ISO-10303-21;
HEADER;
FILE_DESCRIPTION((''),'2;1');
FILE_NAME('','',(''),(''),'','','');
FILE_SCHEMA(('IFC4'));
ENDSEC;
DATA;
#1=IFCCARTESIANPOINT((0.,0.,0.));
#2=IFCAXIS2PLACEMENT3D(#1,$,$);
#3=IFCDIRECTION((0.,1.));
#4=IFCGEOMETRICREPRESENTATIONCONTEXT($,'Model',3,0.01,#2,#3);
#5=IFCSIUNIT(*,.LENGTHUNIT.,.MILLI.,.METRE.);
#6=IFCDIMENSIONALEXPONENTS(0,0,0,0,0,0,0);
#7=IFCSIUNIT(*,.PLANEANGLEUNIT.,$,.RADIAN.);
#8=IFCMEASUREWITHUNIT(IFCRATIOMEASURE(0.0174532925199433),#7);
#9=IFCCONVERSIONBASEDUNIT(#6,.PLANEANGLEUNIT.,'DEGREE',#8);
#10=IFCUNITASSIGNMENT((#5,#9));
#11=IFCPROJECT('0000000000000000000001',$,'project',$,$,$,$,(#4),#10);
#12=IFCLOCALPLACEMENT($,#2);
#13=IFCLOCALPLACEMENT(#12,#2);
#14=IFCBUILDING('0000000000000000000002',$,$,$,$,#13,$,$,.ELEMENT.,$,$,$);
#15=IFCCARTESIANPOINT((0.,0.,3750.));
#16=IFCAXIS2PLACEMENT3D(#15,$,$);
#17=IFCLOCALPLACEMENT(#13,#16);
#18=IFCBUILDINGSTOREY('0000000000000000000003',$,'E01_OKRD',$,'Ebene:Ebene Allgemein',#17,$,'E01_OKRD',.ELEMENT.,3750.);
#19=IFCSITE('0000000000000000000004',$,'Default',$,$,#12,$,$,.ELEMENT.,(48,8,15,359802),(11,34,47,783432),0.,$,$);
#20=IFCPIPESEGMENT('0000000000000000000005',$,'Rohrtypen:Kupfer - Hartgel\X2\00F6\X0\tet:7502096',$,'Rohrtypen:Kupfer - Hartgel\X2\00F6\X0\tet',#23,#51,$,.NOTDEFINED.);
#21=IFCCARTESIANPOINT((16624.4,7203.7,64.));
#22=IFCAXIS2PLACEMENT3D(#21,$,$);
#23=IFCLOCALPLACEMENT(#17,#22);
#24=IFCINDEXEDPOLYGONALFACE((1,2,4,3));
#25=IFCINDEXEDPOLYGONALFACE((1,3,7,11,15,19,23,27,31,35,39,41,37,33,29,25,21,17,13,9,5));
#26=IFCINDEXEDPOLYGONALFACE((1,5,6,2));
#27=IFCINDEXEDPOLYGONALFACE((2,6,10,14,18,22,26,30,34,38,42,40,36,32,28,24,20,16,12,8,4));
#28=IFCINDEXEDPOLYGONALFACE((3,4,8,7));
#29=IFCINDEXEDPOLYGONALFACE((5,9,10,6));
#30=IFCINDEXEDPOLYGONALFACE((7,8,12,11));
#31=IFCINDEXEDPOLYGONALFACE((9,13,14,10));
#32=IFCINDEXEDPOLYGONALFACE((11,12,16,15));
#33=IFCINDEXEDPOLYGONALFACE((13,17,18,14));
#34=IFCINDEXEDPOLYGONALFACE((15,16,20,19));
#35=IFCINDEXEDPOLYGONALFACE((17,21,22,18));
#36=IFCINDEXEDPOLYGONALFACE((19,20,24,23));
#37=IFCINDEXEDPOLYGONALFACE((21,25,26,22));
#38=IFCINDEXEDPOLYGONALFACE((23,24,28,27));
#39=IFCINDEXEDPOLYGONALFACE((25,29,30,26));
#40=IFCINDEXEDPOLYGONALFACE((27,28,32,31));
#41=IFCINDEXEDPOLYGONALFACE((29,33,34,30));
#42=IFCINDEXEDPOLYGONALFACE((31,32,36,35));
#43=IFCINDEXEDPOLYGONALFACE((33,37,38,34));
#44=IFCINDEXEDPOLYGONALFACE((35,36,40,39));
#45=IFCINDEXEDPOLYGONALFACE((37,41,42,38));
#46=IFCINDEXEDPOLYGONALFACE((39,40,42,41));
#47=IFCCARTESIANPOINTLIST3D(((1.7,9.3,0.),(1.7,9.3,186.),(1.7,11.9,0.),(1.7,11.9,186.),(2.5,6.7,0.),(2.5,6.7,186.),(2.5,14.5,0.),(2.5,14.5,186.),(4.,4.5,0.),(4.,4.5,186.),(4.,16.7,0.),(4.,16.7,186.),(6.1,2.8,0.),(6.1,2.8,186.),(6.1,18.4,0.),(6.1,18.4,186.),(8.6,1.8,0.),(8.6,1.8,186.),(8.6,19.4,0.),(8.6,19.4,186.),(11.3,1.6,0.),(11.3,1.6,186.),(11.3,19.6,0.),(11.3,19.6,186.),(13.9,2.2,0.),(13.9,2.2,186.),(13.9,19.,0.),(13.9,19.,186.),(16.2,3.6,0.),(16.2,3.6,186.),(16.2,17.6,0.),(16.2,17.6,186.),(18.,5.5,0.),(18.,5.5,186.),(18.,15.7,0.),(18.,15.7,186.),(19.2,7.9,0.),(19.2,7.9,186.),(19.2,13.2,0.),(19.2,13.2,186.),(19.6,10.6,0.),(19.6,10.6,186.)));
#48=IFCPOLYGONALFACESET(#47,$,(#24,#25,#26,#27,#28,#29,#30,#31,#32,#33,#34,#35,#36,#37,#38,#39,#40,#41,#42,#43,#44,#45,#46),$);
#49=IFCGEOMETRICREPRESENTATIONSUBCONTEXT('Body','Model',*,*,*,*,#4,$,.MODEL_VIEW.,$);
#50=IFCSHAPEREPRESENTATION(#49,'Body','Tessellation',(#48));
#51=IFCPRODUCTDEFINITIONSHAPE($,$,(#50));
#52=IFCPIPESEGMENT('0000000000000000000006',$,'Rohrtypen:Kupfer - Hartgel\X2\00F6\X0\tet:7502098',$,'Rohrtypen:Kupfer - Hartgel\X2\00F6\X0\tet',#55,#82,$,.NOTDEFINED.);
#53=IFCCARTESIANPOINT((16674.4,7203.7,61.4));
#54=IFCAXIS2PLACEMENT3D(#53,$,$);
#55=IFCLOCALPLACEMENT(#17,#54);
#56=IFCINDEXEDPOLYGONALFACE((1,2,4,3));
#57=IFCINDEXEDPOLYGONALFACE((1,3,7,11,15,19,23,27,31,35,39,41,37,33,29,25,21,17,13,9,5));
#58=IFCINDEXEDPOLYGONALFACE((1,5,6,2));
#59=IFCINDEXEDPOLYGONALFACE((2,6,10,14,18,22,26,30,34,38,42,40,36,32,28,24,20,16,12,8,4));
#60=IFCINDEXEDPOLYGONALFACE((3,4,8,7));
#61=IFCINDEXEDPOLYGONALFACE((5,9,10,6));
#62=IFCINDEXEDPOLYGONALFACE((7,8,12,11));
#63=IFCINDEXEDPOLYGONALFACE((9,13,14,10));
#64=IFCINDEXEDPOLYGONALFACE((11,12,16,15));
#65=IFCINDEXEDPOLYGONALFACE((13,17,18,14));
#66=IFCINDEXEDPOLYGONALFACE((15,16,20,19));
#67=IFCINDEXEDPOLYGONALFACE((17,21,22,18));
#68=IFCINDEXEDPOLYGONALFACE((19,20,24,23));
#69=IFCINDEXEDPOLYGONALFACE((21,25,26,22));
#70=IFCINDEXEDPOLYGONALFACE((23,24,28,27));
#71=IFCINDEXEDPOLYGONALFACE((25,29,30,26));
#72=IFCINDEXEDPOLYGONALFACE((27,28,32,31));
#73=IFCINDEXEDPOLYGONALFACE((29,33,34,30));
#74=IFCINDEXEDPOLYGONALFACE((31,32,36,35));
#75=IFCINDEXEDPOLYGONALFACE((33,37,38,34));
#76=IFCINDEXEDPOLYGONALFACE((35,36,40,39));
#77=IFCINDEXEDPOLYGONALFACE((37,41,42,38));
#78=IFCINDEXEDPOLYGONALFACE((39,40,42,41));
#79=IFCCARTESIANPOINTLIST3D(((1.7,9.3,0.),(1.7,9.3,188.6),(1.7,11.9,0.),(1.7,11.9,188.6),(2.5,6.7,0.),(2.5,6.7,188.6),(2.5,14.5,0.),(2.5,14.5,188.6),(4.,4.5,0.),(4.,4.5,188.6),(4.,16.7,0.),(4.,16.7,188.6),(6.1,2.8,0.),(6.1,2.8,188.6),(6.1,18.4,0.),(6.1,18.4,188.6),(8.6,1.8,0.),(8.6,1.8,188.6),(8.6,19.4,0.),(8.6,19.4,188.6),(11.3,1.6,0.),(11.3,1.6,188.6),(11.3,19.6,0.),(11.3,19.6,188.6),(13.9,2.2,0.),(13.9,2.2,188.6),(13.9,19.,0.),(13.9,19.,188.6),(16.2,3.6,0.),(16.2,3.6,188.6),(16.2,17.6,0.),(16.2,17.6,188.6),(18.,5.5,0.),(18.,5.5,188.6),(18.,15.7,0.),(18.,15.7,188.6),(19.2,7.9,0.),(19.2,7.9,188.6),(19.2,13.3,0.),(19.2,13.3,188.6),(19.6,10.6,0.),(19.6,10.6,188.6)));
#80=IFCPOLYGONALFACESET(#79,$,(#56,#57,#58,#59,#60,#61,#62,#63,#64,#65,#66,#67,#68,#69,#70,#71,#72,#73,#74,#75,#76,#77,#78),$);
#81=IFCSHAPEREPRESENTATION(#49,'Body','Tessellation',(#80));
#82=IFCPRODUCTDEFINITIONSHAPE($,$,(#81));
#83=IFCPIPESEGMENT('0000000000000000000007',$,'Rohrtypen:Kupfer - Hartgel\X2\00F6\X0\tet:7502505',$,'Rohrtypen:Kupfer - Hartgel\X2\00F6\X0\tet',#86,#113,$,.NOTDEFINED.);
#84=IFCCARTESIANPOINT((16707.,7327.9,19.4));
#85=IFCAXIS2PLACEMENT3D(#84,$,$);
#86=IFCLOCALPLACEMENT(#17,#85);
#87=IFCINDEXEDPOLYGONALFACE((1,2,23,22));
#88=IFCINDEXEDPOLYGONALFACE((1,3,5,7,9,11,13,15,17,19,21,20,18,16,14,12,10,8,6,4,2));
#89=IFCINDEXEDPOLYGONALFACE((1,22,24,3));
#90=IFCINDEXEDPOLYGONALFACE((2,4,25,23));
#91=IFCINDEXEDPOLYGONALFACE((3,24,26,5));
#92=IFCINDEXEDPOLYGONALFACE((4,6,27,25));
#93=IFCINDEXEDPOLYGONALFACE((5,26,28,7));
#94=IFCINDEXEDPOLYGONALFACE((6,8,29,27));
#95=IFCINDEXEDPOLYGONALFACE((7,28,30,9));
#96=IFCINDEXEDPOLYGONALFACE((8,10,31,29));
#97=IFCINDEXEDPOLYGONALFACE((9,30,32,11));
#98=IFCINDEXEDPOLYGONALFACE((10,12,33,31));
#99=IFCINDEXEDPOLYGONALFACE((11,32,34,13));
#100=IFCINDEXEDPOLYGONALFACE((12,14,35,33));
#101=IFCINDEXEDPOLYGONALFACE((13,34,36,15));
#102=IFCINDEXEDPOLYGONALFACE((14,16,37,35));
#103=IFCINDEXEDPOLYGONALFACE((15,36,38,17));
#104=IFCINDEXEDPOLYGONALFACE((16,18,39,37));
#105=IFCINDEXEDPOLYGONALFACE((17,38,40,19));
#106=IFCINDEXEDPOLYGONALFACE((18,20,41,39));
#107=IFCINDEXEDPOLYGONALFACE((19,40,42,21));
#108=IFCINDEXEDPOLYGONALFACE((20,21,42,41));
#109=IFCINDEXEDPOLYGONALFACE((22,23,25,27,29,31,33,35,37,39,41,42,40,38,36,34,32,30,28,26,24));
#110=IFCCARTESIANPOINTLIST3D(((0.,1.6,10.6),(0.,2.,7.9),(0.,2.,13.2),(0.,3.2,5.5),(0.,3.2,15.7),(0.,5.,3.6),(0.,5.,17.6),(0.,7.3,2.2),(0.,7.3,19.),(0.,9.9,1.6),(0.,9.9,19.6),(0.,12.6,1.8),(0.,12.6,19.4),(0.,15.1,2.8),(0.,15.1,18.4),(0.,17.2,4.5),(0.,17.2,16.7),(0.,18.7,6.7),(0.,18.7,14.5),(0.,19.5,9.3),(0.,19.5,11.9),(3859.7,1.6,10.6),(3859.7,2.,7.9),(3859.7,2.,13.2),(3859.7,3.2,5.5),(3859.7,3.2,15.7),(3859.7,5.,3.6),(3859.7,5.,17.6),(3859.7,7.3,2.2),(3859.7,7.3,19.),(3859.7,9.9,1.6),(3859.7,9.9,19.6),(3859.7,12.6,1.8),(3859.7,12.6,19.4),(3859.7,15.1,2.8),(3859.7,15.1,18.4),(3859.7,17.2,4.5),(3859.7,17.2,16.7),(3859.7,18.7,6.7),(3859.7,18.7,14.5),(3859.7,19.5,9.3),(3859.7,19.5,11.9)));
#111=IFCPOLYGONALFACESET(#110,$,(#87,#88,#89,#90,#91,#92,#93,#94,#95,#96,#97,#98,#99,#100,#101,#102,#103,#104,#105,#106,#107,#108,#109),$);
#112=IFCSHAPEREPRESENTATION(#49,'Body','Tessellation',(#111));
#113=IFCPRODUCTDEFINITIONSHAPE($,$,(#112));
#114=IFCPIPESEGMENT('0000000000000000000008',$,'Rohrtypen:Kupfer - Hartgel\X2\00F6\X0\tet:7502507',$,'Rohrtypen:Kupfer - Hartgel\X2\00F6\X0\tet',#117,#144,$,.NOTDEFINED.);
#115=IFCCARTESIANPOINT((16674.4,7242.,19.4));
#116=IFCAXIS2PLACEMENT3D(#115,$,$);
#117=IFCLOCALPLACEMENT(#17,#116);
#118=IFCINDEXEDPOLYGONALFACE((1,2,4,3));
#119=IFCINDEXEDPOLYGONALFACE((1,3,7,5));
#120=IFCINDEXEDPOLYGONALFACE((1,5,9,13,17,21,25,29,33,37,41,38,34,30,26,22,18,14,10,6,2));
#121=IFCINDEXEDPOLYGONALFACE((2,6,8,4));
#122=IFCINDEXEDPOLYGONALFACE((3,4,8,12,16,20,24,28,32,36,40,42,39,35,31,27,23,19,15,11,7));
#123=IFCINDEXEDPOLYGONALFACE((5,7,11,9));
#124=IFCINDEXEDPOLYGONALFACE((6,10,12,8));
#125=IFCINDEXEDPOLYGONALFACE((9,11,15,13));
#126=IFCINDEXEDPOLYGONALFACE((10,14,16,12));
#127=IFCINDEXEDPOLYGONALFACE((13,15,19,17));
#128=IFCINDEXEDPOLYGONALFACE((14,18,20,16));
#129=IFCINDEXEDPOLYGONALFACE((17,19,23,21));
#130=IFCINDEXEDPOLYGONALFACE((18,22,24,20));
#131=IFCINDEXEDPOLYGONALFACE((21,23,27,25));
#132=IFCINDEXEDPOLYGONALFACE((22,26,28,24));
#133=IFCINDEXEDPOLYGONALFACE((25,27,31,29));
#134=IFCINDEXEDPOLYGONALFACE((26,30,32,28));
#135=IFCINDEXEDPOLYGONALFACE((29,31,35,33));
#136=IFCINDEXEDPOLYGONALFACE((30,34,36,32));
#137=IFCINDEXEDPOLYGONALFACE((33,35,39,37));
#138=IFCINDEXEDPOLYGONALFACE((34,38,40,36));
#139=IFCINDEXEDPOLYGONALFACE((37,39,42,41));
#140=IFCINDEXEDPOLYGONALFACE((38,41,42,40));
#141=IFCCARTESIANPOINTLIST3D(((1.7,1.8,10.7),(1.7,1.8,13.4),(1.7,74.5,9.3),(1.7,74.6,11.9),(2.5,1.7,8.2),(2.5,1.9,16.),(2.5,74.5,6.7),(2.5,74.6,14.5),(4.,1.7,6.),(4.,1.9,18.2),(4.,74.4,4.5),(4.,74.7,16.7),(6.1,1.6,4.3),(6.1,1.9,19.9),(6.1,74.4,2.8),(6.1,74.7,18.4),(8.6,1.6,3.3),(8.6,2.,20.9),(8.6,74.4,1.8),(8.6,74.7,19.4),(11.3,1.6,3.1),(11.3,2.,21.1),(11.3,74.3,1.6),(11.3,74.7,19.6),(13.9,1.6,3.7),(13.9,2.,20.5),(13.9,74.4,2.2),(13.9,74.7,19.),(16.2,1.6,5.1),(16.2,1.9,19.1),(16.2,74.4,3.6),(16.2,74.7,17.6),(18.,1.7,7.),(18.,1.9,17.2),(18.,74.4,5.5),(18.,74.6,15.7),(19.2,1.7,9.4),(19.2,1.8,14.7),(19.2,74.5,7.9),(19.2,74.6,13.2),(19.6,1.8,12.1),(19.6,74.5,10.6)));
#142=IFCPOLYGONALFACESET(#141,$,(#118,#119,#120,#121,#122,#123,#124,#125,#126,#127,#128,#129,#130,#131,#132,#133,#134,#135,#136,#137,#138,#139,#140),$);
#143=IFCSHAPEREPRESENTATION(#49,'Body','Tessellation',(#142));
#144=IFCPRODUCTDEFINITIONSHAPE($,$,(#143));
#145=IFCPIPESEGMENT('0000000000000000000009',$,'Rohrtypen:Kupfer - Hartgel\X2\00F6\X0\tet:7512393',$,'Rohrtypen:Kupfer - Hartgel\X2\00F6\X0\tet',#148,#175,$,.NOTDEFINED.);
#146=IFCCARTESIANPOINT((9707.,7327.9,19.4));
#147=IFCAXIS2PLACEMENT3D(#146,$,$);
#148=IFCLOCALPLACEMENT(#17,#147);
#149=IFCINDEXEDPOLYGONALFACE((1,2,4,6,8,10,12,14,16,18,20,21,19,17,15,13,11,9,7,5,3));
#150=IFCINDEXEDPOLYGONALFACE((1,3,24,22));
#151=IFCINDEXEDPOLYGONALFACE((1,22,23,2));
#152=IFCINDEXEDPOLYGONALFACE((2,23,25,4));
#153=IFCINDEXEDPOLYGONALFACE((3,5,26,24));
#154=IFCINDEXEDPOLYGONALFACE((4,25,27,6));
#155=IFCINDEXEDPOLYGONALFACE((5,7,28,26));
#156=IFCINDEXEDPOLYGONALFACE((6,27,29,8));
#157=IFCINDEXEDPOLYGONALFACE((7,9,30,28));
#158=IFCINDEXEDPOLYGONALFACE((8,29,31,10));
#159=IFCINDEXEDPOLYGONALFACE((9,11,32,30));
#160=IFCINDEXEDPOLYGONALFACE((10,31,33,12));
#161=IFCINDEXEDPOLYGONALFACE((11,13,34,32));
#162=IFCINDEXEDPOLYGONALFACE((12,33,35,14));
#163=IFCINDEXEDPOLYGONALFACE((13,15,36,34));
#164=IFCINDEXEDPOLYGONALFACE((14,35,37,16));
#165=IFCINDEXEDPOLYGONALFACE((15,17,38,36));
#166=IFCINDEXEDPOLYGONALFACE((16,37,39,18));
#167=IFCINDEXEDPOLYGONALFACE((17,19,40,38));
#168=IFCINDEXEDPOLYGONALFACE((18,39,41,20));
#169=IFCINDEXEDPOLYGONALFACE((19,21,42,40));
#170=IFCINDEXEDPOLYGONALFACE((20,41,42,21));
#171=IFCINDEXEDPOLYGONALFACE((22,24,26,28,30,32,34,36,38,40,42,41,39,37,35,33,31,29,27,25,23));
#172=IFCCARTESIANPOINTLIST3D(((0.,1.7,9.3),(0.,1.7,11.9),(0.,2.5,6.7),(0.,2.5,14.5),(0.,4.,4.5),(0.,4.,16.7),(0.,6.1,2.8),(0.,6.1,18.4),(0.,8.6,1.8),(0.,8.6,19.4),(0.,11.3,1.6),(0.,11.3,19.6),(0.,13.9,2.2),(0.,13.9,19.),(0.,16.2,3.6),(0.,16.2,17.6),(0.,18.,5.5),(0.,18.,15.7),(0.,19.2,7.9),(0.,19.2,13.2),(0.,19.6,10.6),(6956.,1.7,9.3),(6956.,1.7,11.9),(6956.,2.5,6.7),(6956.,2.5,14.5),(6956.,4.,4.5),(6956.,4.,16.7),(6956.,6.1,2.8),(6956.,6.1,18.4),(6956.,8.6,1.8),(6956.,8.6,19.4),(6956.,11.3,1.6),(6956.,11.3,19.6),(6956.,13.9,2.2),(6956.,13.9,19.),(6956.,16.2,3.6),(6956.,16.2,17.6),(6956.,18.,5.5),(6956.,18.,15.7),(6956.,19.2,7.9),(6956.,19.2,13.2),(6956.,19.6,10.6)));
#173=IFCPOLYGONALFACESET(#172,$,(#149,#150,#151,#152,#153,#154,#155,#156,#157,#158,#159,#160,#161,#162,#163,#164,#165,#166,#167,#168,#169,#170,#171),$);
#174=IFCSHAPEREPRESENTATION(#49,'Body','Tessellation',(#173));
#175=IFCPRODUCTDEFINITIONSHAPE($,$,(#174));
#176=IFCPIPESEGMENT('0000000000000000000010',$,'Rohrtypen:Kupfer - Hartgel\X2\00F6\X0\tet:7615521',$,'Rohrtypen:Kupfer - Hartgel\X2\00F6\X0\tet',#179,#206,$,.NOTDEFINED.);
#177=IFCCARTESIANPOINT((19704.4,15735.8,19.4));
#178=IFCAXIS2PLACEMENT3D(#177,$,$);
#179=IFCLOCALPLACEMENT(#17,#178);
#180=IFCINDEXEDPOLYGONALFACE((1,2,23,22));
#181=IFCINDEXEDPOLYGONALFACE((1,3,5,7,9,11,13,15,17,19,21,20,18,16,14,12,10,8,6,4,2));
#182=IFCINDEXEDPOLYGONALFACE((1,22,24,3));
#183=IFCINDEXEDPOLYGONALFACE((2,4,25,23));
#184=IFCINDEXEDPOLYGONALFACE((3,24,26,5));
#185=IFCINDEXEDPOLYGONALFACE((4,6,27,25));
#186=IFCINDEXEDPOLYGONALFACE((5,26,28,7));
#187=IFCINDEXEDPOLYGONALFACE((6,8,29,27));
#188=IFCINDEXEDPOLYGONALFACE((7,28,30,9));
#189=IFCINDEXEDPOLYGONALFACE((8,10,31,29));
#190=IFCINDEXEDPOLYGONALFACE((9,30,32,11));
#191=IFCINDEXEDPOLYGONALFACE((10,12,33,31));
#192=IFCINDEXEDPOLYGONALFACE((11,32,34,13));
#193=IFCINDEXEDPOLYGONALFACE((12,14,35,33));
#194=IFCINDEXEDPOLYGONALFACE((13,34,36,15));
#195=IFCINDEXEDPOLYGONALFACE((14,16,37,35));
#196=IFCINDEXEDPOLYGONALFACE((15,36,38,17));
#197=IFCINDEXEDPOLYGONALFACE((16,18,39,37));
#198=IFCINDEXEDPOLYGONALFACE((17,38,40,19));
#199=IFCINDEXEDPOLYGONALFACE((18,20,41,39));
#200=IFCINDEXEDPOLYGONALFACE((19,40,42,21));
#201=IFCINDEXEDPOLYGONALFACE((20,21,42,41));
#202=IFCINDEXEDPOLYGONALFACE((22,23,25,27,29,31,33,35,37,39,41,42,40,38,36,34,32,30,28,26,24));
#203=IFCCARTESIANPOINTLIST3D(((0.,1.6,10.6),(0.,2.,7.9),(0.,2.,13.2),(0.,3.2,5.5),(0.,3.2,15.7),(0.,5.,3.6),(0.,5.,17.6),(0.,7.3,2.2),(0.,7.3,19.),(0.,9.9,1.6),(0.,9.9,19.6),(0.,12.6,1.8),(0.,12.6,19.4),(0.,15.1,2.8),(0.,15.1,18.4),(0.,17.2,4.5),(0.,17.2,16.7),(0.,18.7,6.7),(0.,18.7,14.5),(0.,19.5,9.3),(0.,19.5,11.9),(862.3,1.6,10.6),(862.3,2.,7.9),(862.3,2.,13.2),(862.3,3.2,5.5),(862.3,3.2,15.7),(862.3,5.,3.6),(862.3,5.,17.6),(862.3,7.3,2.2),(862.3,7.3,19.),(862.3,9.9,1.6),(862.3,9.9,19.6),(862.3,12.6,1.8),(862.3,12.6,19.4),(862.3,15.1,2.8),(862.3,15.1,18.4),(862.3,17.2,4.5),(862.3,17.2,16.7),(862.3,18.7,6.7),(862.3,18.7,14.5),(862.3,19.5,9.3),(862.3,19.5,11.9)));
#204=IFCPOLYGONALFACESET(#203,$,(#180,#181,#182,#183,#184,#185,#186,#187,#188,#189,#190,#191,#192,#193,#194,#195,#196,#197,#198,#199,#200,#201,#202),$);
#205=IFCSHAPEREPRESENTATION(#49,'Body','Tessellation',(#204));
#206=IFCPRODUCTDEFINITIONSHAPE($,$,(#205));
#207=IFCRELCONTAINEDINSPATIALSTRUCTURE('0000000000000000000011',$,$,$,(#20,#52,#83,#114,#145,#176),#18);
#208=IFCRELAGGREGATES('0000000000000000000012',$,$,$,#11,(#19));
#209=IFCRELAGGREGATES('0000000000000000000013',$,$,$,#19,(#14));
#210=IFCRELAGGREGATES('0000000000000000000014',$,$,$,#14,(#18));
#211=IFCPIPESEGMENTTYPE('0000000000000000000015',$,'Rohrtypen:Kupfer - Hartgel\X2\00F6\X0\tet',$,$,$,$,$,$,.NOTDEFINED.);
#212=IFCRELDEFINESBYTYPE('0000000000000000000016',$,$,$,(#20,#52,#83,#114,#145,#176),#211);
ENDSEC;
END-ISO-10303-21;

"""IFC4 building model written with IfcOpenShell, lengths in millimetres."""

from ifc_helpers import new_model, entity, si_unit, converted_unit, direction, frame, frame_2d, origin, origin_2d_with_axis, place, context, subcontext, project, spatial, circle, extrude, type_object, element, save


model = new_model("IFC4")

# Units and contexts
model_context = context("Model", 3, precision=0.01, world=origin(), true_north=direction((0.0, 1.0)))
body_context = subcontext(model_context, "Body", "Model", "MODEL_VIEW")
ifc_project = project(units=[si_unit("LENGTHUNIT", "METRE", prefix="MILLI"), converted_unit("PLANEANGLEUNIT", "DEGREE", entity("IfcRatioMeasure", 0.0174532925199433), si_unit("PLANEANGLEUNIT", "RADIAN"), dimensions=[0, 0, 0, 0, 0, 0, 0])], contexts=[model_context])

# Site, building, storey
site_placement = place(None, origin())
site = spatial("IfcSite", under=ifc_project, at=site_placement, Name="Default", CompositionType="ELEMENT", RefLatitude=(48, 8, 15, 359802), RefLongitude=(11, 34, 47, 783432), RefElevation=0.0)
building_placement = place(site_placement, origin())
building = spatial("IfcBuilding", under=site, at=building_placement, CompositionType="ELEMENT")
storey_placement = place(building_placement, frame((0.0, 0.0, 3750.0)))
storey = spatial("IfcBuildingStorey", under=building, at=storey_placement, Name="E01_OKRD", ObjectType="Ebene:Ebene Allgemein", LongName="E01_OKRD", CompositionType="ELEMENT", Elevation=3750.0)

# Pipe segments
pipe_segment_type = type_object("IfcPipeSegmentType", Name="Rohrtypen:Kupfer - Hartgelötet", PredefinedType="NOTDEFINED")
pipe_segment_1_placement = place(storey_placement, frame((16624.4, 7203.7, 64.0)))
element("IfcPipeSegment", 1, at=pipe_segment_1_placement, inside=storey, type_object=pipe_segment_type, Name="Rohrtypen:Kupfer - Hartgelötet:7502096", ObjectType="Rohrtypen:Kupfer - Hartgelötet", PredefinedType="NOTDEFINED", context=body_context, shape_type="SweptSolid", body=[
    extrude(circle(Radius=9.0, at=origin_2d_with_axis()), frame((10.6, 10.6, 0.0)), (0.0, 0.0, 1.0), 186.0),
])
pipe_segment_2_placement = place(storey_placement, frame((16674.4, 7203.7, 61.4)))
element("IfcPipeSegment", 2, at=pipe_segment_2_placement, inside=storey, type_object=pipe_segment_type, Name="Rohrtypen:Kupfer - Hartgelötet:7502098", ObjectType="Rohrtypen:Kupfer - Hartgelötet", PredefinedType="NOTDEFINED", context=body_context, shape_type="SweptSolid", body=[
    extrude(circle(Radius=9.0, at=origin_2d_with_axis()), frame((10.6, 10.6, 0.0)), (0.0, 0.0, 1.0), 188.6),
])
pipe_segment_3_placement = place(storey_placement, frame((16707.0, 7327.9, 19.4)))
element("IfcPipeSegment", 3, at=pipe_segment_3_placement, inside=storey, type_object=pipe_segment_type, Name="Rohrtypen:Kupfer - Hartgelötet:7502505", ObjectType="Rohrtypen:Kupfer - Hartgelötet", PredefinedType="NOTDEFINED", context=body_context, shape_type="SweptSolid", body=[
    extrude(circle(Radius=9.0, at=origin_2d_with_axis()), frame((0.0, 10.6, 10.6), z_axis=(1.0, 0.0, 0.0), x_axis=(0.0, -1.0, 0.0)), (0.0, 0.0, 1.0), 3859.7),
])
pipe_segment_4_placement = place(storey_placement, frame((16674.4, 7242.0, 19.4)))
element("IfcPipeSegment", 4, at=pipe_segment_4_placement, inside=storey, type_object=pipe_segment_type, Name="Rohrtypen:Kupfer - Hartgelötet:7502507", ObjectType="Rohrtypen:Kupfer - Hartgelötet", PredefinedType="NOTDEFINED", context=body_context, shape_type="SweptSolid", body=[
    extrude(circle(Radius=9.0, at=frame_2d((0.0, 0.0), x_axis=(1.0, 0.0))), frame((10.6, 74.5, 10.6), z_axis=(0.0, -0.999789, 0.02054), x_axis=(1.0, 0.0, 0.0)), (0.0, 0.0, 1.0), 72.8),
])
pipe_segment_5_placement = place(storey_placement, frame((9707.0, 7327.9, 19.4)))
element("IfcPipeSegment", 5, at=pipe_segment_5_placement, inside=storey, type_object=pipe_segment_type, Name="Rohrtypen:Kupfer - Hartgelötet:7512393", ObjectType="Rohrtypen:Kupfer - Hartgelötet", PredefinedType="NOTDEFINED", context=body_context, shape_type="SweptSolid", body=[
    extrude(circle(Radius=9.0, at=origin_2d_with_axis()), frame((0.0, 10.6, 10.6), z_axis=(1.0, 0.0, 0.0), x_axis=(0.0, 1.0, 0.0)), (0.0, 0.0, 1.0), 6956.0),
])
pipe_segment_6_placement = place(storey_placement, frame((19704.4, 15735.8, 19.4)))
element("IfcPipeSegment", 6, at=pipe_segment_6_placement, inside=storey, type_object=pipe_segment_type, Name="Rohrtypen:Kupfer - Hartgelötet:7615521", ObjectType="Rohrtypen:Kupfer - Hartgelötet", PredefinedType="NOTDEFINED", context=body_context, shape_type="SweptSolid", body=[
    extrude(circle(Radius=9.0, at=origin_2d_with_axis()), frame((0.0, 10.6, 10.6), z_axis=(1.0, 0.0, 0.0), x_axis=(0.0, -1.0, 0.0)), (0.0, 0.0, 1.0), 862.3),
])

save(model, "model.ifc")
